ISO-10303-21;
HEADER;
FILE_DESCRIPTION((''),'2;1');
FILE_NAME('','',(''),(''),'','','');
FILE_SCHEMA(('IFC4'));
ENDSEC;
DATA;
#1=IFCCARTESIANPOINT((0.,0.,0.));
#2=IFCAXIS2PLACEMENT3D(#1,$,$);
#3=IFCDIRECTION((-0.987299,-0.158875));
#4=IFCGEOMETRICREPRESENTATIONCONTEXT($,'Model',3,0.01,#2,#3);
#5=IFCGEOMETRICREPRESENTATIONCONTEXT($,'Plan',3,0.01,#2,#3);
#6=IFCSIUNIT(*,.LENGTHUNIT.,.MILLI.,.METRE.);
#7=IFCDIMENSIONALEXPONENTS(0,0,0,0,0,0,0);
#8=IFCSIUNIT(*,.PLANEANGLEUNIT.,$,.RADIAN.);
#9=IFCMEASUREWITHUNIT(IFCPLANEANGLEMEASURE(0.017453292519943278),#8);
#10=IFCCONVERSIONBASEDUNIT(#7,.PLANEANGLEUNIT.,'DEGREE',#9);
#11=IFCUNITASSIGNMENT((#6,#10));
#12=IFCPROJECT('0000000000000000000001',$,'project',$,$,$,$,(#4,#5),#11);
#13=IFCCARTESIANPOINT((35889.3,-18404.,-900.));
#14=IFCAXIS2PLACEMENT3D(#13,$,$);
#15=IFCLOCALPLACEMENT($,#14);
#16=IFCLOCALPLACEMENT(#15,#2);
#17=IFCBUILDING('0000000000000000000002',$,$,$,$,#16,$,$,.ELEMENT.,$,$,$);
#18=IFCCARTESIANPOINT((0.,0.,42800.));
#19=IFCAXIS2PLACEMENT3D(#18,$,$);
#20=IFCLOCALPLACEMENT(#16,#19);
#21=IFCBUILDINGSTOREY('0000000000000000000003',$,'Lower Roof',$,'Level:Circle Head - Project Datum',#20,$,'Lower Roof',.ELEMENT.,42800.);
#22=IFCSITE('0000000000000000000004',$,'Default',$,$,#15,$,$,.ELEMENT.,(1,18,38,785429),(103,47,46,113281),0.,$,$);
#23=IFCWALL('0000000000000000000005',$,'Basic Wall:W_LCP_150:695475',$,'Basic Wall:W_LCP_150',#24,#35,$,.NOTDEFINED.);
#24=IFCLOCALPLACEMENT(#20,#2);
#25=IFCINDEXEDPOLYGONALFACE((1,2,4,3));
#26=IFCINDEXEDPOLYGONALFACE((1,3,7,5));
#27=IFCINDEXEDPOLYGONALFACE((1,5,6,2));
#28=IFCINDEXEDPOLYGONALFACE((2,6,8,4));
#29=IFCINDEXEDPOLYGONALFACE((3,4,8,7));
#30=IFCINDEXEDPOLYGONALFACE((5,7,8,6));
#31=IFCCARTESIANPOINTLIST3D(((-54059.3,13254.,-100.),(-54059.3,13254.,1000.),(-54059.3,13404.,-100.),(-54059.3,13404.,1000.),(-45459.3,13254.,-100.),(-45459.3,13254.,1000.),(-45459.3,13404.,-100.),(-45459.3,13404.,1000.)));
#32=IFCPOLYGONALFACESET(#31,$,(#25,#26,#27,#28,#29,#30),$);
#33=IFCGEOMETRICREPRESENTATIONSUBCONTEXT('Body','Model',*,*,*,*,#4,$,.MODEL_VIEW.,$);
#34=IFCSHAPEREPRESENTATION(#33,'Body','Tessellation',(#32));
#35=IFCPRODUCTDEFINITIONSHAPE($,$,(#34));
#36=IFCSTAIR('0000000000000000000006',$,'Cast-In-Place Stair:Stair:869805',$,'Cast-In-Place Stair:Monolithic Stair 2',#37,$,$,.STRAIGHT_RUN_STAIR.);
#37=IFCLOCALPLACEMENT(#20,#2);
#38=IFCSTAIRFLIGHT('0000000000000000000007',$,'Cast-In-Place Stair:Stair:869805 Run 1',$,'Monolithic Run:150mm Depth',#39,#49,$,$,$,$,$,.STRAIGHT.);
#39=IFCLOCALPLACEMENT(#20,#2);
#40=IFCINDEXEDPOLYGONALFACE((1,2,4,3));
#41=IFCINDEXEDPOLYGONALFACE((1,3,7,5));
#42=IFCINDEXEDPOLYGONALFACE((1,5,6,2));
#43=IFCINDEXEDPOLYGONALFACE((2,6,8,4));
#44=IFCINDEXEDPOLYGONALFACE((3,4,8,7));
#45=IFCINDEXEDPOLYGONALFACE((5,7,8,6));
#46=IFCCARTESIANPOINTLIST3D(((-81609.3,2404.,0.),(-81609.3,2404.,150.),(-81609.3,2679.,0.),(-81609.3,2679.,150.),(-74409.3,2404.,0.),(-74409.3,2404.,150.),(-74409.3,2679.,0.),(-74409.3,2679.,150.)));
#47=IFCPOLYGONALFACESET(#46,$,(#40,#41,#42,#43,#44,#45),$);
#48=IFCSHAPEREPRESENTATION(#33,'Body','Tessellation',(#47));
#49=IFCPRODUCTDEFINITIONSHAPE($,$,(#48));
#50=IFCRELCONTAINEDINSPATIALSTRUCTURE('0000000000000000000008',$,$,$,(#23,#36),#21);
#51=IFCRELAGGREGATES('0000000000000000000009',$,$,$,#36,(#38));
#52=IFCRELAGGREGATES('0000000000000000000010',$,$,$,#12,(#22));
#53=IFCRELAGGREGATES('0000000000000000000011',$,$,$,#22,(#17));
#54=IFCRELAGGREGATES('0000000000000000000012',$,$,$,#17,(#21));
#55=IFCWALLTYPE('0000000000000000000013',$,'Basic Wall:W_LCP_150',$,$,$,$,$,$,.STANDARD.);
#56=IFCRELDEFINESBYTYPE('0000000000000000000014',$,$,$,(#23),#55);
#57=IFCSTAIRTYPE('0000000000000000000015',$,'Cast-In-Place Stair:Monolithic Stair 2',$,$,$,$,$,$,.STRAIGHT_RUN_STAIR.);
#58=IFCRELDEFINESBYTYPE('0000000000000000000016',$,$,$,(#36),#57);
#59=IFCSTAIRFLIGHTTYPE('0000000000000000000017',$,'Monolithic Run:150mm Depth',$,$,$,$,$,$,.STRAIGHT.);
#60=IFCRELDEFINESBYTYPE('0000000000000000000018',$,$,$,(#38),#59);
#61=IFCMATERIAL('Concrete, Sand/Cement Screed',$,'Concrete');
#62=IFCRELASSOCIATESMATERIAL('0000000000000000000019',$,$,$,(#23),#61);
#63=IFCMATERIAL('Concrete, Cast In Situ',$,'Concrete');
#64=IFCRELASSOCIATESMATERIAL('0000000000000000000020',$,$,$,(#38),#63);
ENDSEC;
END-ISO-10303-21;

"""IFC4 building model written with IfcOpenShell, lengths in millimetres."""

from ifc_helpers import new_model, entity, si_unit, converted_unit, direction, frame, origin, place, context, subcontext, project, spatial, indexed_curve, outline, extrude, material, type_object, element, aggregate, save


model = new_model("IFC4")

# Units and contexts
model_context = context("Model", 3, precision=0.01, world=origin(), true_north=direction((-0.987299, -0.158875)))
plan_context = context("Plan", 3, precision=0.01, world=origin(), true_north=direction((-0.987299, -0.158875)))
body_context = subcontext(model_context, "Body", "Model", "MODEL_VIEW")
ifc_project = project(units=[si_unit("LENGTHUNIT", "METRE", prefix="MILLI"), converted_unit("PLANEANGLEUNIT", "DEGREE", entity("IfcPlaneAngleMeasure", 0.017453292519943278), si_unit("PLANEANGLEUNIT", "RADIAN"), dimensions=[0, 0, 0, 0, 0, 0, 0])], contexts=[model_context, plan_context])

# Site, building, storey
site_placement = place(None, frame((35889.3, -18404.0, -900.0)))
site = spatial("IfcSite", under=ifc_project, at=site_placement, Name="Default", CompositionType="ELEMENT", RefLatitude=(1, 18, 38, 785429), RefLongitude=(103, 47, 46, 113281), RefElevation=0.0)
building_placement = place(site_placement, origin())
building = spatial("IfcBuilding", under=site, at=building_placement, CompositionType="ELEMENT")
storey_placement = place(building_placement, frame((0.0, 0.0, 42800.0)))
storey = spatial("IfcBuildingStorey", under=building, at=storey_placement, Name="Lower Roof", ObjectType="Level:Circle Head - Project Datum", LongName="Lower Roof", CompositionType="ELEMENT", Elevation=42800.0)

# Shared definitions
ifc_material_1 = material(Name="Concrete, Sand/Cement Screed", Category="Concrete")

# Wall
ifc_material_2 = material(Name="Concrete, Cast In Situ", Category="Concrete")
wall_type_1 = type_object("IfcWallType", Name="Basic Wall:W_LCP_150", PredefinedType="STANDARD")
wall_1_placement = place(storey_placement, frame((-54059.3, 13329.0, -100.0)))
element("IfcWall", 1, at=wall_1_placement, inside=storey, type_object=wall_type_1, material=ifc_material_1, Name="Basic Wall:W_LCP_150:695475", ObjectType="Basic Wall:W_LCP_150", PredefinedType="NOTDEFINED", context=body_context, shape_type="SweptSolid", body=[
    extrude(outline(indexed_curve([(8600.0, 75.0), (0.0, 75.0), (0.0, -75.0), (8600.0, -75.0), (8600.0, 75.0)], self_intersect=False)), origin(), (0.0, 0.0, 1.0), 1100.0),
])

# Stair, stair flight
stair_type_1 = type_object("IfcStairType", Name="Cast-In-Place Stair:Monolithic Stair 2", PredefinedType="STRAIGHT_RUN_STAIR")
stair_1_placement = place(storey_placement, origin())
stair_1 = element("IfcStair", 2, at=stair_1_placement, inside=storey, type_object=stair_type_1, Name="Cast-In-Place Stair:Stair:869805", ObjectType="Cast-In-Place Stair:Monolithic Stair 2", PredefinedType="STRAIGHT_RUN_STAIR")
stair_flight_type = type_object("IfcStairFlightType", Name="Monolithic Run:150mm Depth", PredefinedType="STRAIGHT")
stair_flight_placement = place(stair_1_placement, origin())
stair_flight = element("IfcStairFlight", 3, at=stair_flight_placement, type_object=stair_flight_type, material=ifc_material_2, Name="Cast-In-Place Stair:Stair:869805 Run 1", ObjectType="Monolithic Run:150mm Depth", PredefinedType="STRAIGHT", context=body_context, shape_type="SweptSolid", body=[
    extrude(outline(indexed_curve([(-75.0, -137.5), (75.0, -137.5), (75.0, 137.5), (-75.0, 137.5), (-75.0, -137.5)], self_intersect=False)), frame((-81609.3, 2541.5, 75.0), z_axis=(1.0, 0.0, 0.0), x_axis=(0.0, 0.0, -1.0)), (0.0, 0.0, 1.0), 7200.0),
])
aggregate(stair_1, [stair_flight])

save(model, "model.ifc")
